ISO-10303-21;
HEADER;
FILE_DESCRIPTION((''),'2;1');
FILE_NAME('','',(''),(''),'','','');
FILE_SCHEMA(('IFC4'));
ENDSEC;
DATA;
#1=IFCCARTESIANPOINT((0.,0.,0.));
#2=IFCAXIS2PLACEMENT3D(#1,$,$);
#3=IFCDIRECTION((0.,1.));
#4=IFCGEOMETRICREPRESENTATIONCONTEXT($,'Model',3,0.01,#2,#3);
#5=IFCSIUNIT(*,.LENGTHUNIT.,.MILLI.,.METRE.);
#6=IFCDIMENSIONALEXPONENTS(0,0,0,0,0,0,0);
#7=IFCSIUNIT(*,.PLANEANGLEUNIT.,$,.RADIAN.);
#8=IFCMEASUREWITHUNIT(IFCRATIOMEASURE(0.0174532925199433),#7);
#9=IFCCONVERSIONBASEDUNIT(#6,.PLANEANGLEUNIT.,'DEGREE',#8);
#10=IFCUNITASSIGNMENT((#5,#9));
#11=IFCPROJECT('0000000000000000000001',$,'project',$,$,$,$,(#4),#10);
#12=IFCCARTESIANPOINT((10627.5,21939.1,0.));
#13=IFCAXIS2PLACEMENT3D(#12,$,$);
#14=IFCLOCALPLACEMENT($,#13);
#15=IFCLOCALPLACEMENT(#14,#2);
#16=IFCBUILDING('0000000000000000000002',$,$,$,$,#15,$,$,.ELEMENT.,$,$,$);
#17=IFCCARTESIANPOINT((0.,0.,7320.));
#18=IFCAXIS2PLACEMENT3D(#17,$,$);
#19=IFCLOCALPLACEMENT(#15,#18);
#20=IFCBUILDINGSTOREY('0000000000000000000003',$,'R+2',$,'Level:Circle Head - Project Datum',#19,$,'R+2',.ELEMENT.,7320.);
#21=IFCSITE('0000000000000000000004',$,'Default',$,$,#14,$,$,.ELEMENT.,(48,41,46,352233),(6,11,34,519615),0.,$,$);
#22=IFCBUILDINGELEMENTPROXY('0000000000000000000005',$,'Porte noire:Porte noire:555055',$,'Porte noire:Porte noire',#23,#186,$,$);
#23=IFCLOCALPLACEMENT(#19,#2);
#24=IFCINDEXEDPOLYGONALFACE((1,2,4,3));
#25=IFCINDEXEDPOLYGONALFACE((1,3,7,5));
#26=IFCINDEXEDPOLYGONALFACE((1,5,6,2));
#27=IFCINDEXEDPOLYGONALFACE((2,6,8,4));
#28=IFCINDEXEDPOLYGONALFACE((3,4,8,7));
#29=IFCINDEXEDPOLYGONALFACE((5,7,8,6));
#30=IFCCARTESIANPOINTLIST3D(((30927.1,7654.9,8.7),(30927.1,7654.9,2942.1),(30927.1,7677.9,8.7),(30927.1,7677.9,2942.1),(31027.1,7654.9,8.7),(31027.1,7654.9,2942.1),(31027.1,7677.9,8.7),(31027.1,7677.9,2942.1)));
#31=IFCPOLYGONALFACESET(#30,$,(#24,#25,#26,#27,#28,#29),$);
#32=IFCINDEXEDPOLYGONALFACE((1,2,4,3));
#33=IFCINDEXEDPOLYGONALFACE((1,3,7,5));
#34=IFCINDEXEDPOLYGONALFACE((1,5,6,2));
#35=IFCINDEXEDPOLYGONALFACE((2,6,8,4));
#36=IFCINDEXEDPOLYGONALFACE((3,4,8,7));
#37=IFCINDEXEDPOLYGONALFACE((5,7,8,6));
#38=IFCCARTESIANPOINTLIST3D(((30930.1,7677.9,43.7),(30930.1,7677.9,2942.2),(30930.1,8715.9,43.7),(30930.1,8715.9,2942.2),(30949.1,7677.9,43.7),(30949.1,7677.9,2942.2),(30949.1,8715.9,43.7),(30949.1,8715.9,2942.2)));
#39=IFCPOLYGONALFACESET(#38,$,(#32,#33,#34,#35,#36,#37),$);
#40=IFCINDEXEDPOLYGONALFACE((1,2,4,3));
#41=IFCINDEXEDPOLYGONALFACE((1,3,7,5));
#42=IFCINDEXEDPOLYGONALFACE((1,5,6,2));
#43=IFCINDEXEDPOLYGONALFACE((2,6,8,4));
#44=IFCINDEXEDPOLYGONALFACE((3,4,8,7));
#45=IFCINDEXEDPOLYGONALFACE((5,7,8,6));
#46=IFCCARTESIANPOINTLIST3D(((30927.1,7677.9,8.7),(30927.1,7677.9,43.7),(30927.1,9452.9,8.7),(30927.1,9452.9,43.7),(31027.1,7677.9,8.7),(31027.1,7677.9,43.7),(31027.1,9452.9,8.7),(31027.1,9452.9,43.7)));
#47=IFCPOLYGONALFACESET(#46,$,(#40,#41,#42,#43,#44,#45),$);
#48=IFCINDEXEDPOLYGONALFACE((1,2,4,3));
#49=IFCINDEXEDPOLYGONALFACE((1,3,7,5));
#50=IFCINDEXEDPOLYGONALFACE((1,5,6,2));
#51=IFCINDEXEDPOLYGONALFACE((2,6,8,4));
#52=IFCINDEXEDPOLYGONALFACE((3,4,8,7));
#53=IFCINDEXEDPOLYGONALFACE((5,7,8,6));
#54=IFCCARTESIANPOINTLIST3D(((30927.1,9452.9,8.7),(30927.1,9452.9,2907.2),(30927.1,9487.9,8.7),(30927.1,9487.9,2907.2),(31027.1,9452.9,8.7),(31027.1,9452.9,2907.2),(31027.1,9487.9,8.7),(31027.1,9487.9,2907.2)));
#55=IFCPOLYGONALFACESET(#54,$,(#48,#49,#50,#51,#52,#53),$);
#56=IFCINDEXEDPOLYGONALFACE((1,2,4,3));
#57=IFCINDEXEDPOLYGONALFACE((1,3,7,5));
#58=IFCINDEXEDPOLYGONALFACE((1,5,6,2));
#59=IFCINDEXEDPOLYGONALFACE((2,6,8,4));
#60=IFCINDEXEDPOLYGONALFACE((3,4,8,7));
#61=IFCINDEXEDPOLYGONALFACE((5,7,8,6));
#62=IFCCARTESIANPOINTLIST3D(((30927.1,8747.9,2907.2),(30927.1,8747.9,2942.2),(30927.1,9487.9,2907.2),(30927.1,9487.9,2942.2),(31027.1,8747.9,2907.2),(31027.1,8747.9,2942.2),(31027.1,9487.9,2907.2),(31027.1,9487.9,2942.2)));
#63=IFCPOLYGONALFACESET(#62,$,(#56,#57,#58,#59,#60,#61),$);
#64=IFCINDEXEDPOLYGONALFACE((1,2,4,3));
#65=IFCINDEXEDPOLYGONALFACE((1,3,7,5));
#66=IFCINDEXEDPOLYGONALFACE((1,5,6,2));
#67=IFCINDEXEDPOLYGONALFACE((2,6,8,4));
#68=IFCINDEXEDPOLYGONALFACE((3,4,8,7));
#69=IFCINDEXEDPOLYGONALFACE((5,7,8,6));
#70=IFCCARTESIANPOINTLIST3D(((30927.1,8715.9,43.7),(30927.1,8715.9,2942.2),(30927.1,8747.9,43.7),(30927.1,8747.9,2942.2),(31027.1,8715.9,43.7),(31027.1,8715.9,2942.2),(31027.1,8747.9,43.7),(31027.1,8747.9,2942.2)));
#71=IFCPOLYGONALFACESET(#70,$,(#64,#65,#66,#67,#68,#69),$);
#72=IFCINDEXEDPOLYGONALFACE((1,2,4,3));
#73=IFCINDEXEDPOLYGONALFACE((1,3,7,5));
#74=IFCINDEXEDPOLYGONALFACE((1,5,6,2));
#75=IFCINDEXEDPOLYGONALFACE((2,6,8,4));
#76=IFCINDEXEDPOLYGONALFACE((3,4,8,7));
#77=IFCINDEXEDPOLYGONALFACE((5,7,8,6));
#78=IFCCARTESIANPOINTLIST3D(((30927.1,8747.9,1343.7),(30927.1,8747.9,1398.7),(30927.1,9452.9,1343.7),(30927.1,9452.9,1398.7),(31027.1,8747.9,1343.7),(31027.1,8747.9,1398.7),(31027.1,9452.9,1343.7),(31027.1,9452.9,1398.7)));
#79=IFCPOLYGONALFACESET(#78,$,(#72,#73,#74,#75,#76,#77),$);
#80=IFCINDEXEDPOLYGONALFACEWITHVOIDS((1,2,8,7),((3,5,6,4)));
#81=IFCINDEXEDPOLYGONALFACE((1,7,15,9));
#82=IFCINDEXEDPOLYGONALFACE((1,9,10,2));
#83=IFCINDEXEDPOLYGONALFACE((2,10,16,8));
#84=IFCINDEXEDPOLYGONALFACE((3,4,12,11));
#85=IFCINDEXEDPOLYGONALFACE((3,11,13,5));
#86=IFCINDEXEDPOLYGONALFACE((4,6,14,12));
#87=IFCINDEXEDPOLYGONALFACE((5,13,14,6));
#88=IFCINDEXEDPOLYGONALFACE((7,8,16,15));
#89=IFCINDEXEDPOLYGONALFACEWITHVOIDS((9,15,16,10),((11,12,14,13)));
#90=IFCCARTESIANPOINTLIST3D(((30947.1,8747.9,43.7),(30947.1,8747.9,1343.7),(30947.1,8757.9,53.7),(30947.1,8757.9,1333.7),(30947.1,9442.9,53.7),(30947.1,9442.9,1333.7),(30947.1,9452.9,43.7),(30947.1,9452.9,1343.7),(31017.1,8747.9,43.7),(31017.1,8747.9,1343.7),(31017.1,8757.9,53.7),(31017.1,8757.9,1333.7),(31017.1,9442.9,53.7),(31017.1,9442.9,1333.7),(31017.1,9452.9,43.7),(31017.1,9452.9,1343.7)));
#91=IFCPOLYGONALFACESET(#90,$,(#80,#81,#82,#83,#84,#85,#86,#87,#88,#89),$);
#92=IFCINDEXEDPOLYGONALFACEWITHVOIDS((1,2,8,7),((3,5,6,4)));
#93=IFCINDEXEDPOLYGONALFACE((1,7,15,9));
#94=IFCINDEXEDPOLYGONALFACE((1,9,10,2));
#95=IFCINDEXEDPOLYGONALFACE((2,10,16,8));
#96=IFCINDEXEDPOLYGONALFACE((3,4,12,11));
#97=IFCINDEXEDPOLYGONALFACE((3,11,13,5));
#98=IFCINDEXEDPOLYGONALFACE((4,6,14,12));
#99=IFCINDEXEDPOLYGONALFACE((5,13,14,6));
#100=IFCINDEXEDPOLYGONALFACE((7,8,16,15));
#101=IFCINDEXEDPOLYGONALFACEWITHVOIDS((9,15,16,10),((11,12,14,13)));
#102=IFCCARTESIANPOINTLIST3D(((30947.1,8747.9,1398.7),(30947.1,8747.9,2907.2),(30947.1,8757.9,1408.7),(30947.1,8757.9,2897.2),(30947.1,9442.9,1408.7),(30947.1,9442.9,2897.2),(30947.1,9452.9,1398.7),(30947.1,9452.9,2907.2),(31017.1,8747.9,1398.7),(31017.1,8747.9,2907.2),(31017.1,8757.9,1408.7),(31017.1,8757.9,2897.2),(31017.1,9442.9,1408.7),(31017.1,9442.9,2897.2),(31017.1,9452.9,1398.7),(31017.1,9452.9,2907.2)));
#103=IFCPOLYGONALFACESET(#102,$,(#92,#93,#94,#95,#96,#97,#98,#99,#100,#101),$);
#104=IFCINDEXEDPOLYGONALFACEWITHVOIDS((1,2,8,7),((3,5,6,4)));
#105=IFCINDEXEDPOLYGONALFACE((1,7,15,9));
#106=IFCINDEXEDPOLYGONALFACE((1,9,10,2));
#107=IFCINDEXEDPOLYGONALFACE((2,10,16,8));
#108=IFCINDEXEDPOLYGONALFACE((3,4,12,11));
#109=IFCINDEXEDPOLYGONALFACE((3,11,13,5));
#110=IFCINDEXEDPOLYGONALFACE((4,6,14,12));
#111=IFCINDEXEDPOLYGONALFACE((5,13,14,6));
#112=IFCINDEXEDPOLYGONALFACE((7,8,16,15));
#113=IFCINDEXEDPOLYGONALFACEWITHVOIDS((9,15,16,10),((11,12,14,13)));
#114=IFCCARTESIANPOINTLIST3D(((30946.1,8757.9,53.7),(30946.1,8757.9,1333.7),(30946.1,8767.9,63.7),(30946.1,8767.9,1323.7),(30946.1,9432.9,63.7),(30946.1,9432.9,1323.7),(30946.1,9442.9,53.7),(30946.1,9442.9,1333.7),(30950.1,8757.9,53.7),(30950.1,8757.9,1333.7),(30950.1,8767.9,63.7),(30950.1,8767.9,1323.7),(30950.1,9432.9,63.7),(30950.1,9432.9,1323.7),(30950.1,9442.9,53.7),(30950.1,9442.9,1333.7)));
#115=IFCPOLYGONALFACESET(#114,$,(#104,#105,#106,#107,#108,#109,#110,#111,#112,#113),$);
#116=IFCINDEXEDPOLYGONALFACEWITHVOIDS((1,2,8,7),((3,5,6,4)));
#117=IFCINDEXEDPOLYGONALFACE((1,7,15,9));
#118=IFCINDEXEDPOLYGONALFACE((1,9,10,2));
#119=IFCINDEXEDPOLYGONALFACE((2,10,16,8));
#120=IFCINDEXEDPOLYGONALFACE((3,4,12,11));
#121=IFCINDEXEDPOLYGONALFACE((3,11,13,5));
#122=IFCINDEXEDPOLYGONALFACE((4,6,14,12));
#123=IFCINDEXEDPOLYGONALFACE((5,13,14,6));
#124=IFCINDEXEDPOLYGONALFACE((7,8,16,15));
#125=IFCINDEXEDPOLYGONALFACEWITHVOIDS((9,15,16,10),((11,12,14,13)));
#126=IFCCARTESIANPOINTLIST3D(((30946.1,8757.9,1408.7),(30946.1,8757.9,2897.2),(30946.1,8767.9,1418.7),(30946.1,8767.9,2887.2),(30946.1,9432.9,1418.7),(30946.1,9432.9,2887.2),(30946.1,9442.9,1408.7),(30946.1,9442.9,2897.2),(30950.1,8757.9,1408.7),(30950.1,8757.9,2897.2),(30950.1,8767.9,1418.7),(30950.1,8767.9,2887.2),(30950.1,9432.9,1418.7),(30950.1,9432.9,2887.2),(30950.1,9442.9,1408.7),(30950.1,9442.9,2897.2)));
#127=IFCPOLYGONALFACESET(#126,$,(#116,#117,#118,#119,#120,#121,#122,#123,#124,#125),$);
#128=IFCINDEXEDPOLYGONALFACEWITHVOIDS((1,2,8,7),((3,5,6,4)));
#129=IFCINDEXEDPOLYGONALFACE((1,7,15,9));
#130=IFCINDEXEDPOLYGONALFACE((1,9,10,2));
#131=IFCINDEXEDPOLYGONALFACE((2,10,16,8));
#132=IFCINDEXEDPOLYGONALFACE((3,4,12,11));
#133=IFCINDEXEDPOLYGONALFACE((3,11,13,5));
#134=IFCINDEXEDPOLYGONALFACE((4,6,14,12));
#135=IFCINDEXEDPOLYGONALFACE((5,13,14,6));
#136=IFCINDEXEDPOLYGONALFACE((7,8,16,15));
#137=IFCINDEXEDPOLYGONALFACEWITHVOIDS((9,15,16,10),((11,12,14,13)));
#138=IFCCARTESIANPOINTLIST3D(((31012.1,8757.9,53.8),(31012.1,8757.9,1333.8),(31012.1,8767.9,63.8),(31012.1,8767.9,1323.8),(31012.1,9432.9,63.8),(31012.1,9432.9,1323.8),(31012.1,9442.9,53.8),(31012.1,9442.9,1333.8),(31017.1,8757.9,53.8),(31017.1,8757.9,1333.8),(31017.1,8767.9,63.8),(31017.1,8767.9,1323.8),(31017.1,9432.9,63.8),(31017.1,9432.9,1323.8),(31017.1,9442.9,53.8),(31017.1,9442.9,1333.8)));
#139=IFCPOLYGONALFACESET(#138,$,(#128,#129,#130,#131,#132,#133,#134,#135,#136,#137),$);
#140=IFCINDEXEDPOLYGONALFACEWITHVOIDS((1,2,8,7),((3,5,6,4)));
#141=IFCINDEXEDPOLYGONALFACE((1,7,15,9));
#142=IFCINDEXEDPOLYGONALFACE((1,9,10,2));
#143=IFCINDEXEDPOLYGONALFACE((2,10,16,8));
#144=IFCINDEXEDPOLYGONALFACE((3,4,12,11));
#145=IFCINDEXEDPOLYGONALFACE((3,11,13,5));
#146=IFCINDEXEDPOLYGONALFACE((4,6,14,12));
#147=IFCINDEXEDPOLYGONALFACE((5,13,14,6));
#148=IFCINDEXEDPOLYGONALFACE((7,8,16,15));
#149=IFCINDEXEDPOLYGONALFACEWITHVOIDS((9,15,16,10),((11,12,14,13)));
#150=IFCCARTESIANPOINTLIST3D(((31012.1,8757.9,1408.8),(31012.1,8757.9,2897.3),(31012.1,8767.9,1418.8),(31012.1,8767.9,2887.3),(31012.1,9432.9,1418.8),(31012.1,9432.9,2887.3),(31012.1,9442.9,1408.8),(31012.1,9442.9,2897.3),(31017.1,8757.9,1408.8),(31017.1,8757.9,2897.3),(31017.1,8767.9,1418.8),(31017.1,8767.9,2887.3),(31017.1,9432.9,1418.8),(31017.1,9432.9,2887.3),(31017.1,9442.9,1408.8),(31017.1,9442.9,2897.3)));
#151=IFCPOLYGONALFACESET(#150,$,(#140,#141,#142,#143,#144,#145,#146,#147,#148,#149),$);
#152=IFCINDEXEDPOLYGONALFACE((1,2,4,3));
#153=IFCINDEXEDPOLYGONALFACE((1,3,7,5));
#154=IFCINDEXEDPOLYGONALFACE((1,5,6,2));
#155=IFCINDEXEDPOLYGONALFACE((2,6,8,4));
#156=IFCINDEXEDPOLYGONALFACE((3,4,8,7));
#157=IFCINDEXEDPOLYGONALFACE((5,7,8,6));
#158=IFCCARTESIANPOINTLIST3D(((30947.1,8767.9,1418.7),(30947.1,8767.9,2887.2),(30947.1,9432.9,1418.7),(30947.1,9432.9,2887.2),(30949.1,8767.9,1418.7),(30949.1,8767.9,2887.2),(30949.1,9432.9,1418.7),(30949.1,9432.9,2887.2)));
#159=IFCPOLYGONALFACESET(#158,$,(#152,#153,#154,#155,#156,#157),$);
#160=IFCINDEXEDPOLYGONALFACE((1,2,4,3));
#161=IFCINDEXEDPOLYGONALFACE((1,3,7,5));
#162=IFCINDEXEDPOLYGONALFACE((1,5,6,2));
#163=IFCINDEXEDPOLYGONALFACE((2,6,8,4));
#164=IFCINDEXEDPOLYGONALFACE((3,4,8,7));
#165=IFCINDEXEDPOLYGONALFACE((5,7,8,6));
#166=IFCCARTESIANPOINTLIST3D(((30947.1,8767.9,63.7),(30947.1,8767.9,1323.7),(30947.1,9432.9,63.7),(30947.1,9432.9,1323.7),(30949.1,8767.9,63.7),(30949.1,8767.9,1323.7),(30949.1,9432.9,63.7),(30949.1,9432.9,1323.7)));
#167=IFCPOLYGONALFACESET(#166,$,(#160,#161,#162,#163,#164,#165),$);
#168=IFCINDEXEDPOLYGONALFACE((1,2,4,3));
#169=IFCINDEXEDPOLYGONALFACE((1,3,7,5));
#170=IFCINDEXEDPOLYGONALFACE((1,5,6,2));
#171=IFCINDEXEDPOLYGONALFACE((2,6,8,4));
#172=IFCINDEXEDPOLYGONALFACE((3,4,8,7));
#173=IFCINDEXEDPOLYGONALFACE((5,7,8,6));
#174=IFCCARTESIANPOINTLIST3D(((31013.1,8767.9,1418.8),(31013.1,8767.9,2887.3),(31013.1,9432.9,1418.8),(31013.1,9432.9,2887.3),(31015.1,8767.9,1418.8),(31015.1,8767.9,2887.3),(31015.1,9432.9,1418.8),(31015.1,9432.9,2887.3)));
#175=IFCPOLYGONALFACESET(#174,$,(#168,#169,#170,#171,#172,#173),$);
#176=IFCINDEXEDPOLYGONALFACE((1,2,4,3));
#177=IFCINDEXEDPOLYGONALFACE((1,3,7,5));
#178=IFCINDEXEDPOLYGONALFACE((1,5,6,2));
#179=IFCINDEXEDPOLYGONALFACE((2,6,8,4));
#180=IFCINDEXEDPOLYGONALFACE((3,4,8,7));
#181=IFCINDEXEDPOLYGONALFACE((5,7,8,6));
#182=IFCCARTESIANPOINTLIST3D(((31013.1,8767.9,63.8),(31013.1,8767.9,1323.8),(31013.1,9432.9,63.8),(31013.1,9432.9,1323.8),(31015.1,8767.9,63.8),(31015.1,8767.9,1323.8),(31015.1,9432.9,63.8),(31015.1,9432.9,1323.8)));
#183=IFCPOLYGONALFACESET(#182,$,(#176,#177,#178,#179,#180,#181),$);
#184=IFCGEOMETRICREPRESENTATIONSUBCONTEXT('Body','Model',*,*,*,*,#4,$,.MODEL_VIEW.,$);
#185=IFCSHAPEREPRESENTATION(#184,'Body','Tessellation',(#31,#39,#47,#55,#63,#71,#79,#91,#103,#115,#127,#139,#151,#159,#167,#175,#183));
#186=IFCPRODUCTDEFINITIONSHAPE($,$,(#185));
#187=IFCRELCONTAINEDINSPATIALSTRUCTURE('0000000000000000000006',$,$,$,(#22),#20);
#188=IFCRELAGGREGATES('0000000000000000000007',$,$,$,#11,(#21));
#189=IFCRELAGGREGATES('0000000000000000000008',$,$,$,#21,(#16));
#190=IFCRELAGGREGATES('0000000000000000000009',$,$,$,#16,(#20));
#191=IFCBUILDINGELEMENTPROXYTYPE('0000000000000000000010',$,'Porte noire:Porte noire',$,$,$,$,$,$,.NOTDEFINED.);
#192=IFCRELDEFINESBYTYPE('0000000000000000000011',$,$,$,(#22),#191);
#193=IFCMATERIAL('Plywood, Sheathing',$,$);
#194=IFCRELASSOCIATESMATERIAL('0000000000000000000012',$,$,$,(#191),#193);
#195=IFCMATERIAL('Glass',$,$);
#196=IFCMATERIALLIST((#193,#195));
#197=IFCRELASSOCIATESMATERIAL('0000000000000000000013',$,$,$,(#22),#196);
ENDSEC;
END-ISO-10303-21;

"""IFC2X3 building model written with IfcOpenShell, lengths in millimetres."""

from ifc_helpers import new_model, entity, si_unit, converted_unit, direction, frame, frame_2d, origin, origin_2d_with_axis, place, context, subcontext, project, spatial, polyline, rectangle, outline, extrude, source, transform, mapped, material, material_list, type_object, type_shapes, element, save


model = new_model("IFC2X3")

# Units and contexts
model_context = context("Model", 3, precision=0.01, world=origin(), true_north=direction((0.0, 1.0)))
body_context = subcontext(model_context, "Body", "Model", "MODEL_VIEW")
ifc_project = project(units=[si_unit("LENGTHUNIT", "METRE", prefix="MILLI"), converted_unit("PLANEANGLEUNIT", "DEGREE", entity("IfcRatioMeasure", 0.0174532925199433), si_unit("PLANEANGLEUNIT", "RADIAN"), dimensions=[0, 0, 0, 0, 0, 0, 0])], contexts=[model_context])

# Site, building, storey
site_placement = place(None, frame((10627.5, 21939.1, 0.0)))
site = spatial("IfcSite", under=ifc_project, at=site_placement, Name="Default", CompositionType="ELEMENT", RefLatitude=(48, 41, 46, 352233), RefLongitude=(6, 11, 34, 519615), RefElevation=0.0)
building_placement = place(site_placement, origin())
building = spatial("IfcBuilding", under=site, at=building_placement, CompositionType="ELEMENT")
storey_placement = place(building_placement, frame((0.0, 0.0, 7320.0)))
storey = spatial("IfcBuildingStorey", under=building, at=storey_placement, Name="R+2", ObjectType="Level:Circle Head - Project Datum", LongName="R+2", CompositionType="ELEMENT", Elevation=7320.0)

# Building element proxy
ifc_material_1 = material(Name="Glass")
ifc_material_2 = material(Name="Plywood, Sheathing")
building_element_proxy_type_1 = type_object("IfcBuildingElementProxyType", Name="Porte noire:Porte noire", PredefinedType="NOTDEFINED", material=ifc_material_2)
shared_shape_1 = source(origin(), body_context, "Body", "SweptSolid", [
    extrude(rectangle(XDim=23.0, YDim=100.0, at=frame_2d((0.0, 0.0), x_axis=(1.0, 0.0))), frame((-950.9, 50.0, 8.7), z_axis=(0.0, 0.0, 1.0), x_axis=(-1.0, 0.0, 0.0)), (0.0, 0.0, 1.0), 2933.3),
    extrude(rectangle(XDim=1038.0, YDim=19.0, at=frame_2d((0.0, 0.0), x_axis=(1.0, 0.0))), frame((-420.4, 87.5, 43.7), z_axis=(0.0, 0.0, 1.0), x_axis=(-1.0, 0.0, 0.0)), (0.0, 0.0, 1.0), 2898.5),
    extrude(rectangle(XDim=1775.0, YDim=100.0, at=origin_2d_with_axis()), frame((-51.9, 50.0, 8.7), z_axis=(0.0, 0.0, 1.0), x_axis=(-1.0, 0.0, 0.0)), (0.0, 0.0, 1.0), 35.0),
    extrude(rectangle(XDim=35.0, YDim=100.0, at=origin_2d_with_axis()), frame((853.1, 50.0, 8.7), z_axis=(0.0, 0.0, 1.0), x_axis=(-1.0, 0.0, 0.0)), (0.0, 0.0, 1.0), 2898.5),
    extrude(rectangle(XDim=740.0, YDim=100.0, at=origin_2d_with_axis()), frame((500.6, 50.0, 2907.2), z_axis=(0.0, 0.0, 1.0), x_axis=(-1.0, 0.0, 0.0)), (0.0, 0.0, 1.0), 35.0),
    extrude(rectangle(XDim=32.0, YDim=100.0, at=origin_2d_with_axis()), frame((114.6, 50.0, 43.7), z_axis=(0.0, 0.0, 1.0), x_axis=(-1.0, 0.0, 0.0)), (0.0, 0.0, 1.0), 2898.5),
    extrude(rectangle(XDim=705.0, YDim=100.0, at=origin_2d_with_axis()), frame((483.1, 50.0, 1343.7), z_axis=(0.0, 0.0, 1.0), x_axis=(-1.0, 0.0, 0.0)), (0.0, 0.0, 1.0), 55.0),
    extrude(outline(polyline([(-352.5, -650.0), (352.5, -650.0), (352.5, 650.0), (-352.5, 650.0), (-352.5, -650.0)]), holes=[polyline([(342.5, 640.0), (342.5, -640.0), (-342.5, -640.0), (-342.5, 640.0), (342.5, 640.0)])]), frame((483.1, 10.0, 693.7), z_axis=(0.0, 1.0, 0.0), x_axis=(1.0, 0.0, 0.0)), (0.0, 0.0, 1.0), 70.0),
    extrude(outline(polyline([(-754.2, -352.5), (754.2, -352.5), (754.2, 352.5), (-754.2, 352.5), (-754.2, -352.5)]), holes=[polyline([(744.2, 342.5), (744.2, -342.5), (-744.2, -342.5), (-744.2, 342.5), (744.2, 342.5)])]), frame((483.1, 10.0, 2153.0), z_axis=(0.0, 1.0, 0.0), x_axis=(0.0, 0.0, 1.0)), (0.0, 0.0, 1.0), 70.0),
    extrude(outline(polyline([(-640.0, -342.5), (640.0, -342.5), (640.0, 342.5), (-640.0, 342.5), (-640.0, -342.5)]), holes=[polyline([(630.0, 332.5), (630.0, -332.5), (-630.0, -332.5), (-630.0, 332.5), (630.0, 332.5)])]), frame((483.1, 77.0, 693.7), z_axis=(0.0, 1.0, 0.0), x_axis=(0.0, 0.0, 1.0)), (0.0, 0.0, 1.0), 4.0),
    extrude(outline(polyline([(-744.2, -342.5), (744.2, -342.5), (744.2, 342.5), (-744.2, 342.5), (-744.2, -342.5)]), holes=[polyline([(734.2, 332.5), (734.2, -332.5), (-734.2, -332.5), (-734.2, 332.5), (734.2, 332.5)])]), frame((483.1, 77.0, 2153.0), z_axis=(0.0, 1.0, 0.0), x_axis=(0.0, 0.0, 1.0)), (0.0, 0.0, 1.0), 4.0),
    extrude(outline(polyline([(-640.0, -342.5), (640.0, -342.5), (640.0, 342.5), (-640.0, 342.5), (-640.0, -342.5)]), holes=[polyline([(630.0, 332.5), (630.0, -332.5), (-630.0, -332.5), (-630.0, 332.5), (630.0, 332.5)])]), frame((483.1, 10.0, 693.8), z_axis=(0.0, 1.0, 0.0), x_axis=(0.0, 0.0, 1.0)), (0.0, 0.0, 1.0), 5.0),
    extrude(outline(polyline([(-744.2, -342.5), (744.2, -342.5), (744.2, 342.5), (-744.2, 342.5), (-744.2, -342.5)]), holes=[polyline([(734.2, 332.5), (734.2, -332.5), (-734.2, -332.5), (-734.2, 332.5), (734.2, 332.5)])]), frame((483.1, 10.0, 2153.0), z_axis=(0.0, 1.0, 0.0), x_axis=(0.0, 0.0, 1.0)), (0.0, 0.0, 1.0), 5.0),
    extrude(rectangle(XDim=665.0, YDim=2.0, at=frame_2d((0.0, 0.0), x_axis=(1.0, 0.0))), frame((483.1, 79.0, 1418.7), z_axis=(0.0, 0.0, 1.0), x_axis=(-1.0, 0.0, 0.0)), (0.0, 0.0, 1.0), 1468.5),
    extrude(rectangle(XDim=665.0, YDim=2.0, at=frame_2d((0.0, 0.0), x_axis=(1.0, 0.0))), frame((483.1, 79.0, 63.7), z_axis=(0.0, 0.0, 1.0), x_axis=(-1.0, 0.0, 0.0)), (0.0, 0.0, 1.0), 1260.0),
    extrude(rectangle(XDim=665.0, YDim=2.0, at=frame_2d((0.0, 0.0), x_axis=(1.0, 0.0))), frame((483.1, 13.0, 1418.8), z_axis=(0.0, 0.0, 1.0), x_axis=(-1.0, 0.0, 0.0)), (0.0, 0.0, 1.0), 1468.5),
    extrude(rectangle(XDim=665.0, YDim=2.0, at=frame_2d((0.0, 0.0), x_axis=(1.0, 0.0))), frame((483.1, 13.0, 63.8), z_axis=(0.0, 0.0, 1.0), x_axis=(-1.0, 0.0, 0.0)), (0.0, 0.0, 1.0), 1260.0),
])
type_shapes(building_element_proxy_type_1, [shared_shape_1])
ifc_material_list_1 = material_list([ifc_material_2, ifc_material_1])
proxy_1_placement = place(storey_placement, frame((31027.1, 8617.3, 0.0), z_axis=(0.0, 0.0, 1.0), x_axis=(0.0, 1.0, 0.0)))
element("IfcBuildingElementProxy", 1, at=proxy_1_placement, inside=storey, type_object=building_element_proxy_type_1, material=ifc_material_list_1, Name="Porte noire:Porte noire:555055", ObjectType="Porte noire:Porte noire", context=body_context, shape_type="MappedRepresentation", body=[
    mapped(shared_shape_1, transform((0.0, 0.0, 0.0), scale=1.0)),
])

save(model, "model.ifc")
